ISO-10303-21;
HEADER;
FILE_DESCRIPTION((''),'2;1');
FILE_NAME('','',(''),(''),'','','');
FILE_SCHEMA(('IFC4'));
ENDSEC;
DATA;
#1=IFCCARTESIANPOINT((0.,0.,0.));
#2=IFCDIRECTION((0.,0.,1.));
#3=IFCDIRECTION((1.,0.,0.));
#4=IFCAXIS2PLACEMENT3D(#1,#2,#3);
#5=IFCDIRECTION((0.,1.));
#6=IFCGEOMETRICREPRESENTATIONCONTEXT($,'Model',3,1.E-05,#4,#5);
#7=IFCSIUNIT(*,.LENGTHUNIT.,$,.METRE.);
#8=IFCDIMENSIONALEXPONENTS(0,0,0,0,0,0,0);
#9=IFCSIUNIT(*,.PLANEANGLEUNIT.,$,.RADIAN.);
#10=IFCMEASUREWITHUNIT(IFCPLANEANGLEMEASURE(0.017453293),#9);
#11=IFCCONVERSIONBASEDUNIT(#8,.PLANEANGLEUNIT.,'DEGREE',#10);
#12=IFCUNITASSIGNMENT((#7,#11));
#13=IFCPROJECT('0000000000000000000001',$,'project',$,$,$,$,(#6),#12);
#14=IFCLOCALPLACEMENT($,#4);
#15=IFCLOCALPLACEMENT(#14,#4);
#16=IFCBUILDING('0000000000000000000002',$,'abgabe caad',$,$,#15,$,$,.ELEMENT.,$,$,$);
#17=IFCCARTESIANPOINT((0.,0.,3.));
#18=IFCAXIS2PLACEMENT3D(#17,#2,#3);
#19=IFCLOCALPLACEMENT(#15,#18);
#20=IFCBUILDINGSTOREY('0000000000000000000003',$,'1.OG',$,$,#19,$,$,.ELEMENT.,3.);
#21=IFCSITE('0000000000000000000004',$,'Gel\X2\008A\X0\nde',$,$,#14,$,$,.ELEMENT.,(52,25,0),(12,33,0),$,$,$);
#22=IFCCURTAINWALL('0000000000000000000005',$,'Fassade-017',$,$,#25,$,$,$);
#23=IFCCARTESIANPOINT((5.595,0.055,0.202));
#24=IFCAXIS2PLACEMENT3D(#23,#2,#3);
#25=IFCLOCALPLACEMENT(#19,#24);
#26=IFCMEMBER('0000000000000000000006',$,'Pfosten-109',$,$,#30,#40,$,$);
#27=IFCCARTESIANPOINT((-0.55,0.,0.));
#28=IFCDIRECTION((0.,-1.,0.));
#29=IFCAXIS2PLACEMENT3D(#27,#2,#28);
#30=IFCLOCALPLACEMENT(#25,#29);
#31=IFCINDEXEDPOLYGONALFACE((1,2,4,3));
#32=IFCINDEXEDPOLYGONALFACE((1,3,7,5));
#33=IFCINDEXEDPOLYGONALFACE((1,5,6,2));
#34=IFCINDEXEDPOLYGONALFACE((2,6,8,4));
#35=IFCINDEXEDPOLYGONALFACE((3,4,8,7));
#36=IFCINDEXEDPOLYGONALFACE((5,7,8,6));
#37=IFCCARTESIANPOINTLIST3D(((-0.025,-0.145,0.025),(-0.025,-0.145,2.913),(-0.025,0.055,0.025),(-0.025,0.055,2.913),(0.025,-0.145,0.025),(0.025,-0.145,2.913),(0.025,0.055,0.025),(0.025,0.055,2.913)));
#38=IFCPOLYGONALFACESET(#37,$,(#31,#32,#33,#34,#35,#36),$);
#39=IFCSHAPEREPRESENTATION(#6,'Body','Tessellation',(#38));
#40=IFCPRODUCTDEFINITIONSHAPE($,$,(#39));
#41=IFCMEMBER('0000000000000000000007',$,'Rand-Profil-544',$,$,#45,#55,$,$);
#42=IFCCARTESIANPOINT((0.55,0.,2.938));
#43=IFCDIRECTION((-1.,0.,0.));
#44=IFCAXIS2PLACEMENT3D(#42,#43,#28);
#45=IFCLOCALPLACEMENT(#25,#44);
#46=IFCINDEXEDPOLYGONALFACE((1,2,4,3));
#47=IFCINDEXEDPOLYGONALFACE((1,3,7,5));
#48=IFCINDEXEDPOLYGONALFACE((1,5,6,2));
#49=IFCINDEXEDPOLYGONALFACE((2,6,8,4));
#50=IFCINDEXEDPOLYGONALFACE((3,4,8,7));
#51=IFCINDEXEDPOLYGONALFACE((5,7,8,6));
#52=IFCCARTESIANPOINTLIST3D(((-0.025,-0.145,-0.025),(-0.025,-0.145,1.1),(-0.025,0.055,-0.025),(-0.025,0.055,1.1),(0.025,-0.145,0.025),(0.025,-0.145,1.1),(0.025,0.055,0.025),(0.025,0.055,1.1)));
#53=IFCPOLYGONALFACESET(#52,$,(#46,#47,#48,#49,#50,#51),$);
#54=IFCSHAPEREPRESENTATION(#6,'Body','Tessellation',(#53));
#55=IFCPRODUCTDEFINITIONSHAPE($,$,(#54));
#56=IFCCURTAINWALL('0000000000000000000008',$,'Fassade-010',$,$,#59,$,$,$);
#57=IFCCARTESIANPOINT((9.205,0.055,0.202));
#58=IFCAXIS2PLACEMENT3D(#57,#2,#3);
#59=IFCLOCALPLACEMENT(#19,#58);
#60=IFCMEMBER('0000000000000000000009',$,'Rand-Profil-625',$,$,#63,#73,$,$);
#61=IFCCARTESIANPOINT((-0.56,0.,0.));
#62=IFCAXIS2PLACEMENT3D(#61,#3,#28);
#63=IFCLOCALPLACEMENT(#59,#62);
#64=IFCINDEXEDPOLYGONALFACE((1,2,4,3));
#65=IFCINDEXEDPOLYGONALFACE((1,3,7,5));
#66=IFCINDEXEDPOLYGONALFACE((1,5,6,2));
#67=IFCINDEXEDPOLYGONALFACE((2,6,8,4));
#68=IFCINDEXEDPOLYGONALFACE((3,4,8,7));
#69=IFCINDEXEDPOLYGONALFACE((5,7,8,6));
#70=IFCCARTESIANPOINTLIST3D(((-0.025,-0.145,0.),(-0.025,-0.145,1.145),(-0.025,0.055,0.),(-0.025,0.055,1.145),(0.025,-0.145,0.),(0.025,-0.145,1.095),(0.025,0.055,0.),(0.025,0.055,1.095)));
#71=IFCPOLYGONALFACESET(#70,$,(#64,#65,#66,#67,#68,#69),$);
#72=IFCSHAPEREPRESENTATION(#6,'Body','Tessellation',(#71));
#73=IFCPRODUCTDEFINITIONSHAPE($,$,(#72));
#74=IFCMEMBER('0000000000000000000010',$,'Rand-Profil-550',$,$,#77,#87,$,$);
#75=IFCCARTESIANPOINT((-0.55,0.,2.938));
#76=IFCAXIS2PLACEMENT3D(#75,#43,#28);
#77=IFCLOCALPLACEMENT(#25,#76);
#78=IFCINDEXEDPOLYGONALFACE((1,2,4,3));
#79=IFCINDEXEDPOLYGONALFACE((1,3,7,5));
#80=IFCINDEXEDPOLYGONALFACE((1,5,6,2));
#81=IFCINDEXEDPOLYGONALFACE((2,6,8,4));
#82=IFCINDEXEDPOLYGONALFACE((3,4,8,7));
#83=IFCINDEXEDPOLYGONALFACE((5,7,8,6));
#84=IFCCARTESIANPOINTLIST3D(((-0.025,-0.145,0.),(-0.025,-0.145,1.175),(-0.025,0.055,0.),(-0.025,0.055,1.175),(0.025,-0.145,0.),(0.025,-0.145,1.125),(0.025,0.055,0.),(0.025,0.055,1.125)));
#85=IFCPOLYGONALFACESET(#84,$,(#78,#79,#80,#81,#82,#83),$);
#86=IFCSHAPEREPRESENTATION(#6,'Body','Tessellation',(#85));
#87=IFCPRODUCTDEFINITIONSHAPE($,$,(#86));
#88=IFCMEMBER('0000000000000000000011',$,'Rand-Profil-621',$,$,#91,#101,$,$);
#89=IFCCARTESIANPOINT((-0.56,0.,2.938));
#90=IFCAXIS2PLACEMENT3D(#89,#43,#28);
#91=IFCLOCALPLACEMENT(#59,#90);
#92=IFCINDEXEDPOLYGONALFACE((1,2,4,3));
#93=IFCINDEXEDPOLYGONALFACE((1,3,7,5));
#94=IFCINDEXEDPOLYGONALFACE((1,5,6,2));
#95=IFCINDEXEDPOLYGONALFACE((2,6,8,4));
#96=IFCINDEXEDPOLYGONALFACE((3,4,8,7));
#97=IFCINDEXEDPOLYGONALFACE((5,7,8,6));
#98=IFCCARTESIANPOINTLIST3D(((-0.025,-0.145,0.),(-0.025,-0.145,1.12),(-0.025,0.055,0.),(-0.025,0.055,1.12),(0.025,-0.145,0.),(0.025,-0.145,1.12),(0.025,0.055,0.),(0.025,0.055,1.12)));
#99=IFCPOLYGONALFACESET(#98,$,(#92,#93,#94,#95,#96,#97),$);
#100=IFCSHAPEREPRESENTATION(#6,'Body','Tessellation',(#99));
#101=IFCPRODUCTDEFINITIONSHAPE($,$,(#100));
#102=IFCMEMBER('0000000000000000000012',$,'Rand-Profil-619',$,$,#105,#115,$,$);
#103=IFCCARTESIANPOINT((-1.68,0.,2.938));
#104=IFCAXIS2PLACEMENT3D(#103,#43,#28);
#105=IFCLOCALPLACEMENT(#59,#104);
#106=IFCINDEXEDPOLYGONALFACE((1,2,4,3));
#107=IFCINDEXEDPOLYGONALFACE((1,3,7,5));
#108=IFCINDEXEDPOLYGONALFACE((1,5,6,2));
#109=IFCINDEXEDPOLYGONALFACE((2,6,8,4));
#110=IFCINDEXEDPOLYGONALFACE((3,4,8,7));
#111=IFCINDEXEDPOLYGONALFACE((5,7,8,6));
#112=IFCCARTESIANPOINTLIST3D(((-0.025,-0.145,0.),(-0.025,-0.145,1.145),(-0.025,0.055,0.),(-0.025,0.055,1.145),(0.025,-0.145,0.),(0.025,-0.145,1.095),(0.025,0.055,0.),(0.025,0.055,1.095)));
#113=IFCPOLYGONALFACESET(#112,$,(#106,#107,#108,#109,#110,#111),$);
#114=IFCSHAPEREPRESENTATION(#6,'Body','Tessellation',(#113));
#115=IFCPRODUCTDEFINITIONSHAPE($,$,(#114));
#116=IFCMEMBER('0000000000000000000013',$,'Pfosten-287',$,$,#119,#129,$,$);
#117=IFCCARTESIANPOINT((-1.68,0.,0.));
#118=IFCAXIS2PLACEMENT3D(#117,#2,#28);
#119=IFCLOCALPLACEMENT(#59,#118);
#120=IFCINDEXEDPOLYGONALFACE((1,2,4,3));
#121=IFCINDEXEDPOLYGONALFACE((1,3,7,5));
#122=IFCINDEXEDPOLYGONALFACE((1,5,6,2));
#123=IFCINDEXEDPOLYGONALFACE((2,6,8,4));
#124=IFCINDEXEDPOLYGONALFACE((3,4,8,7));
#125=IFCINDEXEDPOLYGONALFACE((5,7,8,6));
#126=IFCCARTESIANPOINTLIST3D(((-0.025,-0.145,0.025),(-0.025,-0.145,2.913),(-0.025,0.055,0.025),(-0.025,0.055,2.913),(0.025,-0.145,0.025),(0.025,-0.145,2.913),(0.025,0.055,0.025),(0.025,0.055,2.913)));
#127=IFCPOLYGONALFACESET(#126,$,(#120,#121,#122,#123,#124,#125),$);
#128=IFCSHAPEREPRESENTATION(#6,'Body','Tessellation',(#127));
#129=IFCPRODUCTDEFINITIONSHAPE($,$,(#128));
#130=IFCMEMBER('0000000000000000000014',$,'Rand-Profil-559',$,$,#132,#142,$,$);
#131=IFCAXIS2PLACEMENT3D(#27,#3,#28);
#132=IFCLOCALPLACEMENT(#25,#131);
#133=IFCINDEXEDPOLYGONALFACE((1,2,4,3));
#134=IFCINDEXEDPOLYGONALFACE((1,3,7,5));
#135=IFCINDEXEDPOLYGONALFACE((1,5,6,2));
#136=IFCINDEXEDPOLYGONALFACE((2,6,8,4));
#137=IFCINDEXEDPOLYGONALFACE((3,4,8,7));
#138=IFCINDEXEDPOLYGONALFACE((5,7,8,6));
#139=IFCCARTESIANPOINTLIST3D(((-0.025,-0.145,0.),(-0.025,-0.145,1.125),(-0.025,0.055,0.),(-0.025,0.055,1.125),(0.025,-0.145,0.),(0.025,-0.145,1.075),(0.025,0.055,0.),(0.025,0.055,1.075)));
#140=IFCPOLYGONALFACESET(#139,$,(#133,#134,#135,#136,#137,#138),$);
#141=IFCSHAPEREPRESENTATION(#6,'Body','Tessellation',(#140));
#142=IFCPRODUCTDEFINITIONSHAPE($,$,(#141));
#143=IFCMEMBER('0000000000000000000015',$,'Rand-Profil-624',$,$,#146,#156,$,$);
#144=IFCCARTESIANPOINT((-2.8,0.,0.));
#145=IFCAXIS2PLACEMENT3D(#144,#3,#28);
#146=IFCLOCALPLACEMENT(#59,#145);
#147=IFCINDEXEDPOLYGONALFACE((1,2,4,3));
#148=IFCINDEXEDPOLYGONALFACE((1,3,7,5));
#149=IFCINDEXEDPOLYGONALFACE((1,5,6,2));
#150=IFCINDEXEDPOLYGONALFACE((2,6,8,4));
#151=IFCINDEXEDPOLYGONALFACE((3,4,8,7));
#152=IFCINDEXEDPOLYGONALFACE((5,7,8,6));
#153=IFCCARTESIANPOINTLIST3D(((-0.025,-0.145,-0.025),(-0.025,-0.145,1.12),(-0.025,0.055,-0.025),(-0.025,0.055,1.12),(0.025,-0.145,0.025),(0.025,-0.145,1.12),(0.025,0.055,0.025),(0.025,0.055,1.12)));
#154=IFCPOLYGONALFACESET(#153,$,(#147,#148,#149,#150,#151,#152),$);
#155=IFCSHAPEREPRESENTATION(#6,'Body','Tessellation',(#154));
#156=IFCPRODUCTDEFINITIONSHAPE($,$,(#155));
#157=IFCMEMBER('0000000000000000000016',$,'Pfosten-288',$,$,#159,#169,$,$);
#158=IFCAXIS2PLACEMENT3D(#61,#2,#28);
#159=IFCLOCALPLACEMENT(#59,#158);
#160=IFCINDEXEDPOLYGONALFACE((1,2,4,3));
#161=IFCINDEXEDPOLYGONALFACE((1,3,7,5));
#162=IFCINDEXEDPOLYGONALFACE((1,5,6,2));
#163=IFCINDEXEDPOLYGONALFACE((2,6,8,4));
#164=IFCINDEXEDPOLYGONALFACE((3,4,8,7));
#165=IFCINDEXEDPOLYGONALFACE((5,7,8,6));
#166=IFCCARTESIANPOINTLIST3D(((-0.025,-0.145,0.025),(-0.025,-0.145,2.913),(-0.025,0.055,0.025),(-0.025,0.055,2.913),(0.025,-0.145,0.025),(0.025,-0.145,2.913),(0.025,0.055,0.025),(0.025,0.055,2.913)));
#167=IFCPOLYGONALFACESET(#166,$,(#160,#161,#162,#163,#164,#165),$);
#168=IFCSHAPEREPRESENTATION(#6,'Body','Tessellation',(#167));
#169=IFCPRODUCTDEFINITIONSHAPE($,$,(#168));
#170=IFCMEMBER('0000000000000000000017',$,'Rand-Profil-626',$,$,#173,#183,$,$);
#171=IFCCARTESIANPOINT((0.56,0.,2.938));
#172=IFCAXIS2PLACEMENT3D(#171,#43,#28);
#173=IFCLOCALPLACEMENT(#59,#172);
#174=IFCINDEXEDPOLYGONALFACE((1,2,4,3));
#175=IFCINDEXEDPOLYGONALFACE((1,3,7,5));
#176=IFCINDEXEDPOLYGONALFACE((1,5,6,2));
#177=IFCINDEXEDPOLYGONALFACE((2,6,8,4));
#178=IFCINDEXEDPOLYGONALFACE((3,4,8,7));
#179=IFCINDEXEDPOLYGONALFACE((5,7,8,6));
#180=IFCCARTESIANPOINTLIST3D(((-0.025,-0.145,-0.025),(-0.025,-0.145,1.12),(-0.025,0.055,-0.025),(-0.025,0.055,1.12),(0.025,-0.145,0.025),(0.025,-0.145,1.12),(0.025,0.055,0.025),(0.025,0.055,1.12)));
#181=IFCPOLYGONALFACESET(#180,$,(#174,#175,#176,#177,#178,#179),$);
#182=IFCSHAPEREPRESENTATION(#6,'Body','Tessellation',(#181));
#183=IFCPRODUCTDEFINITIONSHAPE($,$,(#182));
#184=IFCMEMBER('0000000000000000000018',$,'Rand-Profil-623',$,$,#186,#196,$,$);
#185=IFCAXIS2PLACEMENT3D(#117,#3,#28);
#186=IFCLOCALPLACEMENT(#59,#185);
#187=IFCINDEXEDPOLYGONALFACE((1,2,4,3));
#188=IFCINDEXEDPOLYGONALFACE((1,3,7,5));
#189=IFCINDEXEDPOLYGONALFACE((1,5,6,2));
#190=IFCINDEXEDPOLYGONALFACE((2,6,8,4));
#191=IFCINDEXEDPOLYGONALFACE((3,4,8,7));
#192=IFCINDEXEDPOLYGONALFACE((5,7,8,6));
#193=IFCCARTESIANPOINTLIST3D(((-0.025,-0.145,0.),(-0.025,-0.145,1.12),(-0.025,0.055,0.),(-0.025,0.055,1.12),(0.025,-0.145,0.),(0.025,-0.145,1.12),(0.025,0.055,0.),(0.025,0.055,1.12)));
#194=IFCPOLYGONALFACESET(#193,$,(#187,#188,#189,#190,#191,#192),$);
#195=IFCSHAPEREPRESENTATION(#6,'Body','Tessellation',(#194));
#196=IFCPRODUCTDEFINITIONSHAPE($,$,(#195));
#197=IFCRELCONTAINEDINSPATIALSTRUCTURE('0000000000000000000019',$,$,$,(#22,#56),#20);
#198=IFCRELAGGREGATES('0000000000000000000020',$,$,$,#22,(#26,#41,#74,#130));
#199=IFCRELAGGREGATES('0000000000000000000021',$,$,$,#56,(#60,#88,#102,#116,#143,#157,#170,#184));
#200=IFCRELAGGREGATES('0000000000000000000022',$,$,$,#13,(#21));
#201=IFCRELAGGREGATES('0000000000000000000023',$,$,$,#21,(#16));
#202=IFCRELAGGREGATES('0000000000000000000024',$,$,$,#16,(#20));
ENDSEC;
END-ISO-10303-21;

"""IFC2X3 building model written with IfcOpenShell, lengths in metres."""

from ifc_helpers import new_model, entity, si_unit, converted_unit, direction, frame, origin_with_axes, place, context, project, spatial, polyline, outline, extrude, clip, halfspace, element, aggregate, save


model = new_model("IFC2X3")

# Units and contexts
model_context = context("Model", 3, precision=1e-05, world=origin_with_axes(), true_north=direction((0.0, 1.0)))
ifc_project = project(units=[si_unit("LENGTHUNIT", "METRE"), converted_unit("PLANEANGLEUNIT", "DEGREE", entity("IfcPlaneAngleMeasure", 0.017453293), si_unit("PLANEANGLEUNIT", "RADIAN"), dimensions=[0, 0, 0, 0, 0, 0, 0])], contexts=[model_context])

# Site, building, storey
site_placement = place(None, origin_with_axes())
site = spatial("IfcSite", under=ifc_project, at=site_placement, Name="Gel\u008ande", CompositionType="ELEMENT", RefLatitude=(52, 25, 0), RefLongitude=(12, 33, 0))
building_placement = place(site_placement, origin_with_axes())
building = spatial("IfcBuilding", under=site, at=building_placement, Name="abgabe caad", CompositionType="ELEMENT")
storey_placement = place(building_placement, frame((0.0, 0.0, 3.0), z_axis=(0.0, 0.0, 1.0), x_axis=(1.0, 0.0, 0.0)))
storey = spatial("IfcBuildingStorey", under=building, at=storey_placement, Name="1.OG", CompositionType="ELEMENT", Elevation=3.0)

# Curtain wall, members
curtain_wall_1_placement = place(storey_placement, frame((5.595, 0.055, 0.202), z_axis=(0.0, 0.0, 1.0), x_axis=(1.0, 0.0, 0.0)))
curtain_wall_1 = element("IfcCurtainWall", 1, at=curtain_wall_1_placement, inside=storey, Name="Fassade-017")
member_1_placement = place(curtain_wall_1_placement, frame((-0.55, 0.0, 0.0), z_axis=(0.0, 0.0, 1.0), x_axis=(0.0, -1.0, 0.0)))
member_1 = element("IfcMember", 2, at=member_1_placement, Name="Pfosten-109", context=model_context, shape_type="SweptSolid", body=[
    extrude(outline(polyline([(-0.145, -0.025), (0.055, -0.025), (0.055, 0.025), (-0.145, 0.025), (-0.145, -0.025)])), frame((0.0, 0.0, 0.025), z_axis=(0.0, 0.0, 1.0), x_axis=(0.0, 1.0, 0.0)), (0.0, 0.0, 1.0), 2.888),
])
member_2_placement = place(curtain_wall_1_placement, frame((0.55, 0.0, 2.938), z_axis=(-1.0, 0.0, 0.0), x_axis=(0.0, -1.0, 0.0)))
member_2 = element("IfcMember", 3, at=member_2_placement, Name="Rand-Profil-544", context=model_context, shape_type="Clipping", body=[
    clip(extrude(outline(polyline([(-0.025, 0.145), (-0.025, -0.055), (0.025, -0.055), (0.025, 0.145), (-0.025, 0.145)])), frame((0.0, 0.0, -0.025), z_axis=(0.0, 0.0, 1.0), x_axis=(-1.0, 0.0, 0.0)), (0.0, 0.0, 1.0), 1.125), halfspace(frame((0.0, 0.0, 0.0), z_axis=(-0.707107, 0.0, 0.707107), x_axis=(-0.707107, 0.0, -0.707107)), True)),
])

# Curtain wall, member
curtain_wall_2_placement = place(storey_placement, frame((9.205, 0.055, 0.202), z_axis=(0.0, 0.0, 1.0), x_axis=(1.0, 0.0, 0.0)))
curtain_wall_2 = element("IfcCurtainWall", 4, at=curtain_wall_2_placement, inside=storey, Name="Fassade-010")
member_3_placement = place(curtain_wall_2_placement, frame((-0.56, 0.0, 0.0), z_axis=(1.0, 0.0, 0.0), x_axis=(0.0, -1.0, 0.0)))
member_3 = element("IfcMember", 5, at=member_3_placement, Name="Rand-Profil-625", context=model_context, shape_type="Clipping", body=[
    clip(extrude(outline(polyline([(0.025, -0.145), (0.025, 0.055), (-0.025, 0.055), (-0.025, -0.145), (0.025, -0.145)])), origin_with_axes(), (0.0, 0.0, 1.0), 1.145), halfspace(frame((0.56, 0.0, 0.56), z_axis=(-0.707107, 0.0, -0.707107), x_axis=(0.707107, 0.0, -0.707107)), True)),
])

# Members
member_4_placement = place(curtain_wall_1_placement, frame((-0.55, 0.0, 2.938), z_axis=(-1.0, 0.0, 0.0), x_axis=(0.0, -1.0, 0.0)))
member_4 = element("IfcMember", 6, at=member_4_placement, Name="Rand-Profil-550", context=model_context, shape_type="Clipping", body=[
    clip(extrude(outline(polyline([(-0.025, 0.145), (-0.025, -0.055), (0.025, -0.055), (0.025, 0.145), (-0.025, 0.145)])), frame((0.0, 0.0, 0.0), z_axis=(0.0, 0.0, 1.0), x_axis=(-1.0, 0.0, 0.0)), (0.0, 0.0, 1.0), 1.175), halfspace(frame((0.575, 0.0, 0.575), z_axis=(-0.707107, 0.0, -0.707107), x_axis=(0.707107, 0.0, -0.707107)), True)),
])
member_5_placement = place(curtain_wall_2_placement, frame((-0.56, 0.0, 2.938), z_axis=(-1.0, 0.0, 0.0), x_axis=(0.0, -1.0, 0.0)))
member_5 = element("IfcMember", 7, at=member_5_placement, Name="Rand-Profil-621", context=model_context, shape_type="SweptSolid", body=[
    extrude(outline(polyline([(-0.025, 0.145), (-0.025, -0.055), (0.025, -0.055), (0.025, 0.145), (-0.025, 0.145)])), frame((0.0, 0.0, 0.0), z_axis=(0.0, 0.0, 1.0), x_axis=(-1.0, 0.0, 0.0)), (0.0, 0.0, 1.0), 1.12),
])
member_6_placement = place(curtain_wall_2_placement, frame((-1.68, 0.0, 2.938), z_axis=(-1.0, 0.0, 0.0), x_axis=(0.0, -1.0, 0.0)))
member_6 = element("IfcMember", 8, at=member_6_placement, Name="Rand-Profil-619", context=model_context, shape_type="Clipping", body=[
    clip(extrude(outline(polyline([(-0.025, 0.145), (-0.025, -0.055), (0.025, -0.055), (0.025, 0.145), (-0.025, 0.145)])), frame((0.0, 0.0, 0.0), z_axis=(0.0, 0.0, 1.0), x_axis=(-1.0, 0.0, 0.0)), (0.0, 0.0, 1.0), 1.145), halfspace(frame((0.56, 0.0, 0.56), z_axis=(-0.707107, 0.0, -0.707107), x_axis=(0.707107, 0.0, -0.707107)), True)),
])
member_7_placement = place(curtain_wall_2_placement, frame((-1.68, 0.0, 0.0), z_axis=(0.0, 0.0, 1.0), x_axis=(0.0, -1.0, 0.0)))
member_7 = element("IfcMember", 9, at=member_7_placement, Name="Pfosten-287", context=model_context, shape_type="SweptSolid", body=[
    extrude(outline(polyline([(-0.145, -0.025), (0.055, -0.025), (0.055, 0.025), (-0.145, 0.025), (-0.145, -0.025)])), frame((0.0, 0.0, 0.025), z_axis=(0.0, 0.0, 1.0), x_axis=(0.0, 1.0, 0.0)), (0.0, 0.0, 1.0), 2.888),
])
member_8_placement = place(curtain_wall_1_placement, frame((-0.55, 0.0, 0.0), z_axis=(1.0, 0.0, 0.0), x_axis=(0.0, -1.0, 0.0)))
member_8 = element("IfcMember", 10, at=member_8_placement, Name="Rand-Profil-559", context=model_context, shape_type="Clipping", body=[
    clip(extrude(outline(polyline([(0.025, -0.145), (0.025, 0.055), (-0.025, 0.055), (-0.025, -0.145), (0.025, -0.145)])), origin_with_axes(), (0.0, 0.0, 1.0), 1.125), halfspace(frame((0.55, 0.0, 0.55), z_axis=(-0.707107, 0.0, -0.707107), x_axis=(0.707107, 0.0, -0.707107)), True)),
])
member_9_placement = place(curtain_wall_2_placement, frame((-2.8, 0.0, 0.0), z_axis=(1.0, 0.0, 0.0), x_axis=(0.0, -1.0, 0.0)))
member_9 = element("IfcMember", 11, at=member_9_placement, Name="Rand-Profil-624", context=model_context, shape_type="Clipping", body=[
    clip(extrude(outline(polyline([(0.025, -0.145), (0.025, 0.055), (-0.025, 0.055), (-0.025, -0.145), (0.025, -0.145)])), frame((0.0, 0.0, -0.025), z_axis=(0.0, 0.0, 1.0), x_axis=(1.0, 0.0, 0.0)), (0.0, 0.0, 1.0), 1.145), halfspace(frame((0.0, 0.0, 0.0), z_axis=(-0.707107, 0.0, 0.707107), x_axis=(-0.707107, 0.0, -0.707107)), True)),
])
member_10_placement = place(curtain_wall_2_placement, frame((-0.56, 0.0, 0.0), z_axis=(0.0, 0.0, 1.0), x_axis=(0.0, -1.0, 0.0)))
member_10 = element("IfcMember", 12, at=member_10_placement, Name="Pfosten-288", context=model_context, shape_type="SweptSolid", body=[
    extrude(outline(polyline([(-0.145, -0.025), (0.055, -0.025), (0.055, 0.025), (-0.145, 0.025), (-0.145, -0.025)])), frame((0.0, 0.0, 0.025), z_axis=(0.0, 0.0, 1.0), x_axis=(0.0, 1.0, 0.0)), (0.0, 0.0, 1.0), 2.888),
])
member_11_placement = place(curtain_wall_2_placement, frame((0.56, 0.0, 2.938), z_axis=(-1.0, 0.0, 0.0), x_axis=(0.0, -1.0, 0.0)))
member_11 = element("IfcMember", 13, at=member_11_placement, Name="Rand-Profil-626", context=model_context, shape_type="Clipping", body=[
    clip(extrude(outline(polyline([(-0.025, 0.145), (-0.025, -0.055), (0.025, -0.055), (0.025, 0.145), (-0.025, 0.145)])), frame((0.0, 0.0, -0.025), z_axis=(0.0, 0.0, 1.0), x_axis=(-1.0, 0.0, 0.0)), (0.0, 0.0, 1.0), 1.145), halfspace(frame((0.0, 0.0, 0.0), z_axis=(-0.707107, 0.0, 0.707107), x_axis=(-0.707107, 0.0, -0.707107)), True)),
])
member_12_placement = place(curtain_wall_2_placement, frame((-1.68, 0.0, 0.0), z_axis=(1.0, 0.0, 0.0), x_axis=(0.0, -1.0, 0.0)))
member_12 = element("IfcMember", 14, at=member_12_placement, Name="Rand-Profil-623", context=model_context, shape_type="SweptSolid", body=[
    extrude(outline(polyline([(0.025, -0.145), (0.025, 0.055), (-0.025, 0.055), (-0.025, -0.145), (0.025, -0.145)])), origin_with_axes(), (0.0, 0.0, 1.0), 1.12),
])

aggregate(curtain_wall_1, [member_1, member_2, member_4, member_8])
aggregate(curtain_wall_2, [member_3, member_5, member_6, member_7, member_9, member_10, member_11, member_12])

save(model, "model.ifc")
